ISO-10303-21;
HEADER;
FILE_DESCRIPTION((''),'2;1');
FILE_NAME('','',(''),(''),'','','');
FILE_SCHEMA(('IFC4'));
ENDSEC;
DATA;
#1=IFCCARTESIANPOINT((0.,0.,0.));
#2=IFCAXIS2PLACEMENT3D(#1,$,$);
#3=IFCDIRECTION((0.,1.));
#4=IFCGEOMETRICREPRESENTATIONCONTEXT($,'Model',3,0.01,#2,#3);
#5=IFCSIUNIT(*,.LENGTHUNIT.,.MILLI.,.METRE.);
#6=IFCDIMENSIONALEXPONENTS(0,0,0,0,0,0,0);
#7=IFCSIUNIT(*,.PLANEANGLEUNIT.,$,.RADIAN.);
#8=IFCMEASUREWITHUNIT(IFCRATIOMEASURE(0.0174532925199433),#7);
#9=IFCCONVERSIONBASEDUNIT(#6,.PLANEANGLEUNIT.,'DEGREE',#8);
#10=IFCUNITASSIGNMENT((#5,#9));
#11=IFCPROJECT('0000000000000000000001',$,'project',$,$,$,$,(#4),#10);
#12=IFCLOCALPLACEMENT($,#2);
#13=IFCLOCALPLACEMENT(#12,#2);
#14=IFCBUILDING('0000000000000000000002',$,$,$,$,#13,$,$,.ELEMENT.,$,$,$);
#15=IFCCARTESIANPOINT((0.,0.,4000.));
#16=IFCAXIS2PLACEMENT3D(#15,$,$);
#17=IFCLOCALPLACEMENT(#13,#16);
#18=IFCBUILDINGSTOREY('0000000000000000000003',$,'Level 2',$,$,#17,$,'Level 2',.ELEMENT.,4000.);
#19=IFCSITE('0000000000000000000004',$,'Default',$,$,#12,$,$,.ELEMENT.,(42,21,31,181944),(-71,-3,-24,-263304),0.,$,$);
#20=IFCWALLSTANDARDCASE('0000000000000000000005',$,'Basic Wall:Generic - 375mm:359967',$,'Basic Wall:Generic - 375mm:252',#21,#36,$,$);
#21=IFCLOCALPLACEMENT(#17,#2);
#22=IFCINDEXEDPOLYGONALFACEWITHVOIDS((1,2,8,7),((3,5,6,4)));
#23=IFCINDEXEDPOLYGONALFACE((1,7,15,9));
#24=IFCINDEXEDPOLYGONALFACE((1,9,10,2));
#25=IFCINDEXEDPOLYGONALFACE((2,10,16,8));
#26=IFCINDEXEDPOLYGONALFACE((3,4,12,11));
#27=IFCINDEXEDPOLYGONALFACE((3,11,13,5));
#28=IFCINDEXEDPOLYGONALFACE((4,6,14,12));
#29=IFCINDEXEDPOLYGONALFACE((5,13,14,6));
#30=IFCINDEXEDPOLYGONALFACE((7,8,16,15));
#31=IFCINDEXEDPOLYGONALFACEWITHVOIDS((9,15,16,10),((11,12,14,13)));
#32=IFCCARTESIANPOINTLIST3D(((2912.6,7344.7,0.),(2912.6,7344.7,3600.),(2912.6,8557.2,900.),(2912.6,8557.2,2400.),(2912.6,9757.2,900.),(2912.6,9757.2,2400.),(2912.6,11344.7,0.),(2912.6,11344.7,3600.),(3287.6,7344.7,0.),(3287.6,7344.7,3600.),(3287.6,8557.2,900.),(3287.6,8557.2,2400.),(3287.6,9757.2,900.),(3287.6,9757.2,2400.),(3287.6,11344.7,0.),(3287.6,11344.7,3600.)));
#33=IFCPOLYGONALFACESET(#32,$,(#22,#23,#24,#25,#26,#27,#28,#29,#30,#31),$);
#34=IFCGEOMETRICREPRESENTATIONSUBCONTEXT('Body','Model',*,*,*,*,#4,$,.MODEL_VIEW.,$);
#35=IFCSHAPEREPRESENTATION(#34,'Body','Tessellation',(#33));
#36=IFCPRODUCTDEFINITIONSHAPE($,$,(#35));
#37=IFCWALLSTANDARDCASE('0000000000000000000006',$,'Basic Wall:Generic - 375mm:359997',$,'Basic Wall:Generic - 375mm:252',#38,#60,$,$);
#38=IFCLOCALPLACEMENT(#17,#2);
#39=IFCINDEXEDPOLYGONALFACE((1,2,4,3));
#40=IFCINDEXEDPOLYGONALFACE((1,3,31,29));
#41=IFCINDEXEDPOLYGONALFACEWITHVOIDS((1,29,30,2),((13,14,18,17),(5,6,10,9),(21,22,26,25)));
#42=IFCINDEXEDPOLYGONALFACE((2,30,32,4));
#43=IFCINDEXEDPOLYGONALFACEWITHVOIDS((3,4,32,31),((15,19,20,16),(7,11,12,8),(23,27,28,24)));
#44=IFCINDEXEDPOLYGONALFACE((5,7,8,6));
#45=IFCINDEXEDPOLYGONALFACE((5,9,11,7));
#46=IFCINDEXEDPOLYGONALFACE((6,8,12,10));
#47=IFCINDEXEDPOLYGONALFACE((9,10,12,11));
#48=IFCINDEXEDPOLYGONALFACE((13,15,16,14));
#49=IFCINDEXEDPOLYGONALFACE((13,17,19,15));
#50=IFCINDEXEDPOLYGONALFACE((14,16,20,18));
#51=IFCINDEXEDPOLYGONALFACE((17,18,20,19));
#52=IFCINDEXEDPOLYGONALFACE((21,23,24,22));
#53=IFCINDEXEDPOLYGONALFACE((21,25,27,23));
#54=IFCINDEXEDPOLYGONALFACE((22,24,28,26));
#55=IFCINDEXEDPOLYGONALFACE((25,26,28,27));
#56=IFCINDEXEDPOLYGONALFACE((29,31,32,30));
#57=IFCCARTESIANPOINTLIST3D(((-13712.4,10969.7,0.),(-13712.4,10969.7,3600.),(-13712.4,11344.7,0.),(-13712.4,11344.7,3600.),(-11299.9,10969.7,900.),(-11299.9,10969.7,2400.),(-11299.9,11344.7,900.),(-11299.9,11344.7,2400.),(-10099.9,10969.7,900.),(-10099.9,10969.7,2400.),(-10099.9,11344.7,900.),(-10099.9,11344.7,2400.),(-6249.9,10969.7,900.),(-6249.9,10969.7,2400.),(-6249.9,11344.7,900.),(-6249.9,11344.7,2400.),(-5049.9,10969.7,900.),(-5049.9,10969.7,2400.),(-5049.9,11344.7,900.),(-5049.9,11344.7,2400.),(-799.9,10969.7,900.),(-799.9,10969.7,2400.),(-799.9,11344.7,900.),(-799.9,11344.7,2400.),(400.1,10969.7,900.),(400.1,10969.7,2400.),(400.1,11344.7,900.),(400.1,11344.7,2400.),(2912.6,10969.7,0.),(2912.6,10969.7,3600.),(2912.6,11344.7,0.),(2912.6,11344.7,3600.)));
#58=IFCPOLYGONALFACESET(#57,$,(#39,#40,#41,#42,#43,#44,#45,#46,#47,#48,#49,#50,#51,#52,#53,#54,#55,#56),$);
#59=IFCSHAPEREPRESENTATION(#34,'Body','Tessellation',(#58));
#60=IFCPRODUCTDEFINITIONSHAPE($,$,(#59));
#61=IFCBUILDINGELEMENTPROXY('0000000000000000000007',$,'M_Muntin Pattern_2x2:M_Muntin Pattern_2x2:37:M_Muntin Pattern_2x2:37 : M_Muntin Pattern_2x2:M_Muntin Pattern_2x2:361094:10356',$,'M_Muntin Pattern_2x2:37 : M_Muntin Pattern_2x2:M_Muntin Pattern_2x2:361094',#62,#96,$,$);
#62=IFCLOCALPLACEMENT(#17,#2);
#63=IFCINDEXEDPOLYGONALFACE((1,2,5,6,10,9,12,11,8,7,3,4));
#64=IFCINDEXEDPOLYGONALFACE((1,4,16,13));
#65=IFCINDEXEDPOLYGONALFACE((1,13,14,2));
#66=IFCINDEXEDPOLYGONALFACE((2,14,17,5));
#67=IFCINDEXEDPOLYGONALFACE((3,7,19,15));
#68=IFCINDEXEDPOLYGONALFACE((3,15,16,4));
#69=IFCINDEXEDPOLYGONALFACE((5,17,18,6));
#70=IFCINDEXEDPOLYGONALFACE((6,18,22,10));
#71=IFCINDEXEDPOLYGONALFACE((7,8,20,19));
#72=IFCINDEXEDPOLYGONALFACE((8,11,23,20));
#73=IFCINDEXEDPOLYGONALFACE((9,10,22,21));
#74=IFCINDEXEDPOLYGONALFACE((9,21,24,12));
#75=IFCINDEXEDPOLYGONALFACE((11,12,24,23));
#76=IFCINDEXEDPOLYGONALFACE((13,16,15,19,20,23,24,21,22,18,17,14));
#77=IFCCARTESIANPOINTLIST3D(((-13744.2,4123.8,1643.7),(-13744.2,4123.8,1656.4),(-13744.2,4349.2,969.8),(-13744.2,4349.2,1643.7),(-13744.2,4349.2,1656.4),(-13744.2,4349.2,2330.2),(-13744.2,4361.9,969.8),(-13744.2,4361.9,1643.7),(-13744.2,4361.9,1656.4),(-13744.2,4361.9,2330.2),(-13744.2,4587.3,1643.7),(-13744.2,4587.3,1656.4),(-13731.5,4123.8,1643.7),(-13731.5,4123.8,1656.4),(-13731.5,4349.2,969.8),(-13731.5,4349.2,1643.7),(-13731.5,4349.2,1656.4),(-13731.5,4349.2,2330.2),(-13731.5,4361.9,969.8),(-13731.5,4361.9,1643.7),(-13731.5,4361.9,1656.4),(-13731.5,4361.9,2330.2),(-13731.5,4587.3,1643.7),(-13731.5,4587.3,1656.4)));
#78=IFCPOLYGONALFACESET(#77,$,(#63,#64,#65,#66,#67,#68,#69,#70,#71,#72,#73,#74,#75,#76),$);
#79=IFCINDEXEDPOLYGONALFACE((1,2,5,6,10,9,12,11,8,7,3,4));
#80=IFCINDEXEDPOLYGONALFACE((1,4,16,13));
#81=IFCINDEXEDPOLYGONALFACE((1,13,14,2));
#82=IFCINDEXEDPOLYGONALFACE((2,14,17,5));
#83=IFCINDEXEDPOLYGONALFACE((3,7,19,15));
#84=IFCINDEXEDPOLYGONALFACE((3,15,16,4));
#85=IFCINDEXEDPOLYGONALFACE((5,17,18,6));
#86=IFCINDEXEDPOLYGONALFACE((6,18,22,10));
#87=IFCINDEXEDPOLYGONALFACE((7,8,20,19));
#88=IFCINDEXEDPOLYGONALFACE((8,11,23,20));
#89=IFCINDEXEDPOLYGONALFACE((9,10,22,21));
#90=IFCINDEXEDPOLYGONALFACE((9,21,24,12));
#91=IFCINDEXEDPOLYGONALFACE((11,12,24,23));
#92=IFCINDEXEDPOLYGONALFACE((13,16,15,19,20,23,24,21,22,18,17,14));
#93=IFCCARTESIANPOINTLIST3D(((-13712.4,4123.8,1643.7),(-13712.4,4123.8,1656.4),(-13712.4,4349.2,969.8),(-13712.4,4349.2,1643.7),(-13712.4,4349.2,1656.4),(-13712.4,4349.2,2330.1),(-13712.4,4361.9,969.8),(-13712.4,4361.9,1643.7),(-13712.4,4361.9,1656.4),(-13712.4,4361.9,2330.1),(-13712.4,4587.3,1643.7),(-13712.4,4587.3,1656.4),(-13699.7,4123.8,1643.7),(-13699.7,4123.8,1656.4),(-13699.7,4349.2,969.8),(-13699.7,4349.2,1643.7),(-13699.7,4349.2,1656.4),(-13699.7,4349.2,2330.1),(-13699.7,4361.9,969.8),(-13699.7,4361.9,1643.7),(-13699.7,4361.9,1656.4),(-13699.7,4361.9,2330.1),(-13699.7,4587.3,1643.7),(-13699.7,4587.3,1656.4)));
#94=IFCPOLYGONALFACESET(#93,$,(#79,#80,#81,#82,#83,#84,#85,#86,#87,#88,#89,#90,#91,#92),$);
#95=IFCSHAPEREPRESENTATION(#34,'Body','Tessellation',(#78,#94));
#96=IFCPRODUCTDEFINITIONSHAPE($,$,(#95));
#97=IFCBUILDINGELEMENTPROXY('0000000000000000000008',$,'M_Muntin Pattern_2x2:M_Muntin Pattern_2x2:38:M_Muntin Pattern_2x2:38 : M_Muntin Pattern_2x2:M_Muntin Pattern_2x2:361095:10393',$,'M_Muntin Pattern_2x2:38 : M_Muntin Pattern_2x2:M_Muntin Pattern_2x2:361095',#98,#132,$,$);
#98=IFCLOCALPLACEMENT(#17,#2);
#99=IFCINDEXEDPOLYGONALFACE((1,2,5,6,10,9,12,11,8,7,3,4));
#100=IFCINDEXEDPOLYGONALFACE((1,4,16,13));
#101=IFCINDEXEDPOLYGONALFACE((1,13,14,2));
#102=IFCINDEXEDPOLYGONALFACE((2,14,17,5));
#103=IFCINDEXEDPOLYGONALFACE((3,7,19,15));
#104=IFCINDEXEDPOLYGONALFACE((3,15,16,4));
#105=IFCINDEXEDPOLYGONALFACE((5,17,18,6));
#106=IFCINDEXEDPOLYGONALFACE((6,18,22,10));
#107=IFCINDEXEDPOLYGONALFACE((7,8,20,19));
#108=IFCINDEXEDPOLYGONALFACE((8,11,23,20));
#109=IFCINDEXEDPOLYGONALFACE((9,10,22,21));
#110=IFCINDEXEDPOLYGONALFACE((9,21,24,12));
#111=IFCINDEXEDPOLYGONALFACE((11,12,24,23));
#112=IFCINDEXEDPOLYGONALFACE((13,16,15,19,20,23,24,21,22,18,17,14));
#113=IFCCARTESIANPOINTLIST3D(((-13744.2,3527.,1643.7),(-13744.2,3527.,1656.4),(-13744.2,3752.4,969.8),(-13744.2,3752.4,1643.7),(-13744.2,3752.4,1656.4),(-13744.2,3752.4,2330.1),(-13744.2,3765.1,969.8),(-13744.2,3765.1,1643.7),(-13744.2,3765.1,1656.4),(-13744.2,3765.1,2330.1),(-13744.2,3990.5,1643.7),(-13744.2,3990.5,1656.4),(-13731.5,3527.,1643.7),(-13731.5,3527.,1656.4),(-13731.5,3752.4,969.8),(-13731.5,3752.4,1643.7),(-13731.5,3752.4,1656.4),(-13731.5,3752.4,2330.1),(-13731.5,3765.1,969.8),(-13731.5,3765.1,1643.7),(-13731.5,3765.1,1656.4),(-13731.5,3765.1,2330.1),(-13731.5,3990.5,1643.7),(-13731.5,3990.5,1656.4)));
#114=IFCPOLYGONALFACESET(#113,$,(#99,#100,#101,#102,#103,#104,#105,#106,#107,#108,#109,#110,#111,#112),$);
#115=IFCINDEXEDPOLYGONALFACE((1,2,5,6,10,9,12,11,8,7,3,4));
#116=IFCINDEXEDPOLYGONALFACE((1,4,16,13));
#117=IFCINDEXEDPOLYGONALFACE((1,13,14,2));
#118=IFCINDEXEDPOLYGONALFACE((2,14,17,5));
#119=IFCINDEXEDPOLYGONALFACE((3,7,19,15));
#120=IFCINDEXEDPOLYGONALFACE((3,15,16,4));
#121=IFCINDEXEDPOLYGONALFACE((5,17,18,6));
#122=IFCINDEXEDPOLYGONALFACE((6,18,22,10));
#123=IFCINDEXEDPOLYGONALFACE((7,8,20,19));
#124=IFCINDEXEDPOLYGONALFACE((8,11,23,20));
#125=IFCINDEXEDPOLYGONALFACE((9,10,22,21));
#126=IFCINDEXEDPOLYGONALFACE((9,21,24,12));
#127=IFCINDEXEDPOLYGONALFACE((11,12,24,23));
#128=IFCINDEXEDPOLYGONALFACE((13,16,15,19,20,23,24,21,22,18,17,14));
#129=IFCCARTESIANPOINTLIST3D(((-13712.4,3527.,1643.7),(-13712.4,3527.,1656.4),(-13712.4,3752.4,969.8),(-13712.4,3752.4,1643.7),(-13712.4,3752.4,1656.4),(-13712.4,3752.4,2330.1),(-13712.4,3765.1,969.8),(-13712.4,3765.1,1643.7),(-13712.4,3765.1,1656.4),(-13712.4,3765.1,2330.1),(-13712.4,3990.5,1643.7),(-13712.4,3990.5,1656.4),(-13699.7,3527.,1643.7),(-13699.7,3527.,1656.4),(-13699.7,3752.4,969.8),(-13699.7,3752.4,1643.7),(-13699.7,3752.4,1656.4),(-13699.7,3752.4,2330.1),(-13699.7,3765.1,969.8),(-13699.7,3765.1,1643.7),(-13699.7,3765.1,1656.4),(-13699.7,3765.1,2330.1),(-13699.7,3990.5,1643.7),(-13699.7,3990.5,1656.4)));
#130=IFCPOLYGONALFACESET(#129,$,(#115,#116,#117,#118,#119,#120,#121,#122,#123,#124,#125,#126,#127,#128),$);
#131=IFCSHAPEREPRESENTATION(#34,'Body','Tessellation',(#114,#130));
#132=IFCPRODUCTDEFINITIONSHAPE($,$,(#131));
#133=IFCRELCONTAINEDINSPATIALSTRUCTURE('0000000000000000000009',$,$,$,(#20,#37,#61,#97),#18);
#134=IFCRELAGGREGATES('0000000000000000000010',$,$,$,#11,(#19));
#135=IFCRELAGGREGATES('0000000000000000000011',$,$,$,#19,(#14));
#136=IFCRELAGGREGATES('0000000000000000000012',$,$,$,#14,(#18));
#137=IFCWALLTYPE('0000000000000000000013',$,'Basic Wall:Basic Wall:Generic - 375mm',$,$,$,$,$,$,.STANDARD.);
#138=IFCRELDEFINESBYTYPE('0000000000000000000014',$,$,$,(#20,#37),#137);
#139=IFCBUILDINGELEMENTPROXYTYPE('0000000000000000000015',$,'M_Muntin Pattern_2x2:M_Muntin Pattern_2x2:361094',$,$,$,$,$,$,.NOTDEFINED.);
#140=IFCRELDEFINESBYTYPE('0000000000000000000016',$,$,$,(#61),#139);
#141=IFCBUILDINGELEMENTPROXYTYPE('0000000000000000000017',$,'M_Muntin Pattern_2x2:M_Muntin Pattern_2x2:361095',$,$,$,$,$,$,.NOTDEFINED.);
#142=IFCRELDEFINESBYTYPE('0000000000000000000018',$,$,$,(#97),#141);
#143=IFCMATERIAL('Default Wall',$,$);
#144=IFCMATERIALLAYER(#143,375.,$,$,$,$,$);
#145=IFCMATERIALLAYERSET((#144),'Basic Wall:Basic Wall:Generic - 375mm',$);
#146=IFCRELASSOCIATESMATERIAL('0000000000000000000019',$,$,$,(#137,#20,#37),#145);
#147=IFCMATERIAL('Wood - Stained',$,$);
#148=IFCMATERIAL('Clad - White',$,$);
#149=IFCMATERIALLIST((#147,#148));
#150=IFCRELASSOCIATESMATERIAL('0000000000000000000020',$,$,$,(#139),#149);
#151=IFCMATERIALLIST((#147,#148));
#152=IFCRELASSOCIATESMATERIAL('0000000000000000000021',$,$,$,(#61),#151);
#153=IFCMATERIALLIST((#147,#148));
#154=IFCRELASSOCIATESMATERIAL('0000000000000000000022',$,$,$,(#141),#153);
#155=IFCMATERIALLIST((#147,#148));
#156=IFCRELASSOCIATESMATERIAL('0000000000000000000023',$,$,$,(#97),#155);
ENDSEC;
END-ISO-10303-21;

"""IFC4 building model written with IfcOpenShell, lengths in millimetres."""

from ifc_helpers import new_model, entity, si_unit, converted_unit, direction, frame, frame_2d, origin, place, context, subcontext, project, spatial, polyline, rectangle, outline, extrude, source, transform, mapped, material, material_list, layer, layer_set, layer_usage, type_object, type_shapes, element, save


model = new_model("IFC4")

# Units and contexts
model_context = context("Model", 3, precision=0.01, world=origin(), true_north=direction((0.0, 1.0)))
body_context = subcontext(model_context, "Body", "Model", "MODEL_VIEW")
ifc_project = project(units=[si_unit("LENGTHUNIT", "METRE", prefix="MILLI"), converted_unit("PLANEANGLEUNIT", "DEGREE", entity("IfcRatioMeasure", 0.0174532925199433), si_unit("PLANEANGLEUNIT", "RADIAN"), dimensions=[0, 0, 0, 0, 0, 0, 0])], contexts=[model_context])

# Site, building, storey
site_placement = place(None, origin())
site = spatial("IfcSite", under=ifc_project, at=site_placement, Name="Default", CompositionType="ELEMENT", RefLatitude=(42, 21, 31, 181944), RefLongitude=(-71, -3, -24, -263304), RefElevation=0.0)
building_placement = place(site_placement, origin())
building = spatial("IfcBuilding", under=site, at=building_placement, CompositionType="ELEMENT")
storey_placement = place(building_placement, frame((0.0, 0.0, 4000.0)))
storey = spatial("IfcBuildingStorey", under=building, at=storey_placement, Name="Level 2", LongName="Level 2", CompositionType="ELEMENT", Elevation=4000.0)

# Wall, opening
ifc_material_1 = material(Name="Default Wall")
ifc_layer = layer(ifc_material_1, 375.0)
ifc_layer_set = layer_set([ifc_layer], Name="Basic Wall:Basic Wall:Generic - 375mm")
ifc_layer_usage_1 = layer_usage(ifc_layer_set, "AXIS2", "NEGATIVE", 187.5)
wall_type = type_object("IfcWallType", Name="Basic Wall:Basic Wall:Generic - 375mm", PredefinedType="STANDARD", material=ifc_layer_set)
wall_1_placement = place(storey_placement, frame((3100.1, 7344.7, 0.0), z_axis=(0.0, 0.0, 1.0), x_axis=(0.0, 1.0, 0.0)))
wall_1 = element("IfcWallStandardCase", 1, at=wall_1_placement, inside=storey, type_object=wall_type, material=ifc_layer_usage_1, Name="Basic Wall:Generic - 375mm:359967", ObjectType="Basic Wall:Generic - 375mm:252", context=body_context, shape_type="SweptSolid", body=[
    extrude(rectangle(XDim=4000.0, YDim=375.0, at=frame_2d((2000.0, 0.0), x_axis=(-1.0, 0.0))), origin(), (0.0, 0.0, 1.0), 3600.0),
])
opening_1_placement = place(wall_1_placement, frame((-7344.7, 3100.1, 0.0), z_axis=(0.0, 0.0, 1.0), x_axis=(0.0, -1.0, 0.0)))
element("IfcOpeningElement", 2, at=opening_1_placement, cuts=wall_1, ObjectType="Opening", context=body_context, shape_type="SweptSolid", body=[
    extrude(rectangle(XDim=1500.0, YDim=1200.0, at=frame_2d((0.0, 0.0), x_axis=(0.0, 1.0))), frame((3291.3, 9157.2, 1650.0), z_axis=(-1.0, 0.0, 0.0), x_axis=(0.0, -1.0, 0.0)), (0.0, 0.0, 1.0), 382.5),
])

# Wall, openings
ifc_layer_usage_2 = layer_usage(ifc_layer_set, "AXIS2", "NEGATIVE", 187.5)
wall_2_placement = place(storey_placement, frame((2912.6, 11157.2, 0.0), z_axis=(0.0, 0.0, 1.0), x_axis=(-1.0, 0.0, 0.0)))
wall_2 = element("IfcWallStandardCase", 3, at=wall_2_placement, inside=storey, type_object=wall_type, material=ifc_layer_usage_2, Name="Basic Wall:Generic - 375mm:359997", ObjectType="Basic Wall:Generic - 375mm:252", context=body_context, shape_type="SweptSolid", body=[
    extrude(rectangle(XDim=16625.0, YDim=375.0, at=frame_2d((8312.5, 0.0), x_axis=(-1.0, 0.0))), origin(), (0.0, 0.0, 1.0), 3600.0),
])
opening_2_placement = place(wall_2_placement, frame((2912.6, 11157.2, 0.0), z_axis=(0.0, 0.0, 1.0), x_axis=(-1.0, 0.0, 0.0)))
element("IfcOpeningElement", 4, at=opening_2_placement, cuts=wall_2, ObjectType="Opening", context=body_context, shape_type="SweptSolid", body=[
    extrude(rectangle(XDim=1500.0, YDim=1200.0, at=frame_2d((0.0, 0.0), x_axis=(0.0, 1.0))), frame((-5649.9, 11348.4, 1650.0), z_axis=(0.0, -1.0, 0.0), x_axis=(1.0, 0.0, 0.0)), (0.0, 0.0, 1.0), 382.5),
])
opening_3_placement = place(wall_2_placement, frame((2912.6, 11157.2, 0.0), z_axis=(0.0, 0.0, 1.0), x_axis=(-1.0, 0.0, 0.0)))
element("IfcOpeningElement", 5, at=opening_3_placement, cuts=wall_2, ObjectType="Opening", context=body_context, shape_type="SweptSolid", body=[
    extrude(rectangle(XDim=1500.0, YDim=1200.0, at=frame_2d((0.0, 0.0), x_axis=(0.0, 1.0))), frame((-199.9, 11348.4, 1650.0), z_axis=(0.0, -1.0, 0.0), x_axis=(1.0, 0.0, 0.0)), (0.0, 0.0, 1.0), 382.5),
])
opening_4_placement = place(wall_2_placement, frame((2912.6, 11157.2, 0.0), z_axis=(0.0, 0.0, 1.0), x_axis=(-1.0, 0.0, 0.0)))
element("IfcOpeningElement", 6, at=opening_4_placement, cuts=wall_2, ObjectType="Opening", context=body_context, shape_type="SweptSolid", body=[
    extrude(rectangle(XDim=1500.0, YDim=1200.0, at=frame_2d((0.0, 0.0), x_axis=(0.0, 1.0))), frame((-10699.9, 11348.4, 1650.0), z_axis=(0.0, -1.0, 0.0), x_axis=(1.0, 0.0, 0.0)), (0.0, 0.0, 1.0), 382.5),
])

# Building element proxies
ifc_material_2 = material(Name="Wood - Stained")
ifc_material_3 = material(Name="Clad - White")
ifc_material_list_1 = material_list([ifc_material_2, ifc_material_3])
ifc_material_list_2 = material_list([ifc_material_2, ifc_material_3])
building_element_proxy_type_1 = type_object("IfcBuildingElementProxyType", Name="M_Muntin Pattern_2x2:M_Muntin Pattern_2x2:361094", PredefinedType="NOTDEFINED", material=ifc_material_list_2)
shared_shape_1 = source(origin(), body_context, "Body", "SweptSolid", [
    extrude(outline(polyline([(-6.4, -680.2), (6.3, -680.2), (6.3, -6.4), (231.7, -6.4), (231.7, 6.3), (6.3, 6.3), (6.3, 680.2), (-6.4, 680.2), (-6.4, 6.3), (-231.7, 6.3), (-231.7, -6.4), (-6.4, -6.4), (-6.4, -680.2)])), frame((-13744.2, 4355.6, 5650.0), z_axis=(1.0, 0.0, 0.0), x_axis=(0.0, -1.0, 0.0)), (0.0, 0.0, 1.0), 12.7),
    extrude(outline(polyline([(-6.4, -680.1), (6.3, -680.1), (6.3, -6.4), (231.7, -6.4), (231.7, 6.3), (6.3, 6.3), (6.3, 680.2), (-6.4, 680.2), (-6.4, 6.3), (-231.7, 6.3), (-231.7, -6.4), (-6.4, -6.4), (-6.4, -680.1)])), frame((-13712.4, 4355.6, 5650.0), z_axis=(1.0, 0.0, 0.0), x_axis=(0.0, -1.0, 0.0)), (0.0, 0.0, 1.0), 12.7),
])
type_shapes(building_element_proxy_type_1, [shared_shape_1])
proxy_1_placement = place(storey_placement, frame((0.0, 0.0, -4000.0)))
element("IfcBuildingElementProxy", 7, at=proxy_1_placement, inside=storey, type_object=building_element_proxy_type_1, material=ifc_material_list_1, Name="M_Muntin Pattern_2x2:M_Muntin Pattern_2x2:37:M_Muntin Pattern_2x2:37 : M_Muntin Pattern_2x2:M_Muntin Pattern_2x2:361094:10356", ObjectType="M_Muntin Pattern_2x2:37 : M_Muntin Pattern_2x2:M_Muntin Pattern_2x2:361094", context=body_context, shape_type="MappedRepresentation", body=[
    mapped(shared_shape_1, transform((0.0, 0.0, 0.0), scale=1.0)),
])
ifc_material_list_3 = material_list([ifc_material_2, ifc_material_3])
ifc_material_list_4 = material_list([ifc_material_2, ifc_material_3])
building_element_proxy_type_2 = type_object("IfcBuildingElementProxyType", Name="M_Muntin Pattern_2x2:M_Muntin Pattern_2x2:361095", PredefinedType="NOTDEFINED", material=ifc_material_list_4)
shared_shape_2 = source(origin(), body_context, "Body", "SweptSolid", [
    extrude(outline(polyline([(-680.1, 6.4), (-680.1, -6.3), (-6.4, -6.3), (-6.4, -231.7), (6.3, -231.7), (6.3, -6.3), (680.2, -6.3), (680.2, 6.4), (6.3, 6.4), (6.3, 231.7), (-6.4, 231.7), (-6.4, 6.4), (-680.1, 6.4)])), frame((-13744.2, 3758.7, 5650.0), z_axis=(-1.0, 0.0, 0.0), x_axis=(0.0, 0.0, -1.0)), (0.0, 0.0, -1.0), 12.7),
    extrude(outline(polyline([(-680.1, 6.4), (-680.1, -6.3), (-6.4, -6.3), (-6.4, -231.7), (6.3, -231.7), (6.3, -6.3), (680.2, -6.3), (680.2, 6.4), (6.3, 6.4), (6.3, 231.7), (-6.4, 231.7), (-6.4, 6.4), (-680.1, 6.4)])), frame((-13712.4, 3758.7, 5650.0), z_axis=(-1.0, 0.0, 0.0), x_axis=(0.0, 0.0, -1.0)), (0.0, 0.0, -1.0), 12.7),
])
type_shapes(building_element_proxy_type_2, [shared_shape_2])
proxy_2_placement = place(storey_placement, frame((0.0, 0.0, -4000.0)))
element("IfcBuildingElementProxy", 8, at=proxy_2_placement, inside=storey, type_object=building_element_proxy_type_2, material=ifc_material_list_3, Name="M_Muntin Pattern_2x2:M_Muntin Pattern_2x2:38:M_Muntin Pattern_2x2:38 : M_Muntin Pattern_2x2:M_Muntin Pattern_2x2:361095:10393", ObjectType="M_Muntin Pattern_2x2:38 : M_Muntin Pattern_2x2:M_Muntin Pattern_2x2:361095", context=body_context, shape_type="MappedRepresentation", body=[
    mapped(shared_shape_2, transform((0.0, 0.0, 0.0), scale=1.0)),
])

save(model, "model.ifc")
